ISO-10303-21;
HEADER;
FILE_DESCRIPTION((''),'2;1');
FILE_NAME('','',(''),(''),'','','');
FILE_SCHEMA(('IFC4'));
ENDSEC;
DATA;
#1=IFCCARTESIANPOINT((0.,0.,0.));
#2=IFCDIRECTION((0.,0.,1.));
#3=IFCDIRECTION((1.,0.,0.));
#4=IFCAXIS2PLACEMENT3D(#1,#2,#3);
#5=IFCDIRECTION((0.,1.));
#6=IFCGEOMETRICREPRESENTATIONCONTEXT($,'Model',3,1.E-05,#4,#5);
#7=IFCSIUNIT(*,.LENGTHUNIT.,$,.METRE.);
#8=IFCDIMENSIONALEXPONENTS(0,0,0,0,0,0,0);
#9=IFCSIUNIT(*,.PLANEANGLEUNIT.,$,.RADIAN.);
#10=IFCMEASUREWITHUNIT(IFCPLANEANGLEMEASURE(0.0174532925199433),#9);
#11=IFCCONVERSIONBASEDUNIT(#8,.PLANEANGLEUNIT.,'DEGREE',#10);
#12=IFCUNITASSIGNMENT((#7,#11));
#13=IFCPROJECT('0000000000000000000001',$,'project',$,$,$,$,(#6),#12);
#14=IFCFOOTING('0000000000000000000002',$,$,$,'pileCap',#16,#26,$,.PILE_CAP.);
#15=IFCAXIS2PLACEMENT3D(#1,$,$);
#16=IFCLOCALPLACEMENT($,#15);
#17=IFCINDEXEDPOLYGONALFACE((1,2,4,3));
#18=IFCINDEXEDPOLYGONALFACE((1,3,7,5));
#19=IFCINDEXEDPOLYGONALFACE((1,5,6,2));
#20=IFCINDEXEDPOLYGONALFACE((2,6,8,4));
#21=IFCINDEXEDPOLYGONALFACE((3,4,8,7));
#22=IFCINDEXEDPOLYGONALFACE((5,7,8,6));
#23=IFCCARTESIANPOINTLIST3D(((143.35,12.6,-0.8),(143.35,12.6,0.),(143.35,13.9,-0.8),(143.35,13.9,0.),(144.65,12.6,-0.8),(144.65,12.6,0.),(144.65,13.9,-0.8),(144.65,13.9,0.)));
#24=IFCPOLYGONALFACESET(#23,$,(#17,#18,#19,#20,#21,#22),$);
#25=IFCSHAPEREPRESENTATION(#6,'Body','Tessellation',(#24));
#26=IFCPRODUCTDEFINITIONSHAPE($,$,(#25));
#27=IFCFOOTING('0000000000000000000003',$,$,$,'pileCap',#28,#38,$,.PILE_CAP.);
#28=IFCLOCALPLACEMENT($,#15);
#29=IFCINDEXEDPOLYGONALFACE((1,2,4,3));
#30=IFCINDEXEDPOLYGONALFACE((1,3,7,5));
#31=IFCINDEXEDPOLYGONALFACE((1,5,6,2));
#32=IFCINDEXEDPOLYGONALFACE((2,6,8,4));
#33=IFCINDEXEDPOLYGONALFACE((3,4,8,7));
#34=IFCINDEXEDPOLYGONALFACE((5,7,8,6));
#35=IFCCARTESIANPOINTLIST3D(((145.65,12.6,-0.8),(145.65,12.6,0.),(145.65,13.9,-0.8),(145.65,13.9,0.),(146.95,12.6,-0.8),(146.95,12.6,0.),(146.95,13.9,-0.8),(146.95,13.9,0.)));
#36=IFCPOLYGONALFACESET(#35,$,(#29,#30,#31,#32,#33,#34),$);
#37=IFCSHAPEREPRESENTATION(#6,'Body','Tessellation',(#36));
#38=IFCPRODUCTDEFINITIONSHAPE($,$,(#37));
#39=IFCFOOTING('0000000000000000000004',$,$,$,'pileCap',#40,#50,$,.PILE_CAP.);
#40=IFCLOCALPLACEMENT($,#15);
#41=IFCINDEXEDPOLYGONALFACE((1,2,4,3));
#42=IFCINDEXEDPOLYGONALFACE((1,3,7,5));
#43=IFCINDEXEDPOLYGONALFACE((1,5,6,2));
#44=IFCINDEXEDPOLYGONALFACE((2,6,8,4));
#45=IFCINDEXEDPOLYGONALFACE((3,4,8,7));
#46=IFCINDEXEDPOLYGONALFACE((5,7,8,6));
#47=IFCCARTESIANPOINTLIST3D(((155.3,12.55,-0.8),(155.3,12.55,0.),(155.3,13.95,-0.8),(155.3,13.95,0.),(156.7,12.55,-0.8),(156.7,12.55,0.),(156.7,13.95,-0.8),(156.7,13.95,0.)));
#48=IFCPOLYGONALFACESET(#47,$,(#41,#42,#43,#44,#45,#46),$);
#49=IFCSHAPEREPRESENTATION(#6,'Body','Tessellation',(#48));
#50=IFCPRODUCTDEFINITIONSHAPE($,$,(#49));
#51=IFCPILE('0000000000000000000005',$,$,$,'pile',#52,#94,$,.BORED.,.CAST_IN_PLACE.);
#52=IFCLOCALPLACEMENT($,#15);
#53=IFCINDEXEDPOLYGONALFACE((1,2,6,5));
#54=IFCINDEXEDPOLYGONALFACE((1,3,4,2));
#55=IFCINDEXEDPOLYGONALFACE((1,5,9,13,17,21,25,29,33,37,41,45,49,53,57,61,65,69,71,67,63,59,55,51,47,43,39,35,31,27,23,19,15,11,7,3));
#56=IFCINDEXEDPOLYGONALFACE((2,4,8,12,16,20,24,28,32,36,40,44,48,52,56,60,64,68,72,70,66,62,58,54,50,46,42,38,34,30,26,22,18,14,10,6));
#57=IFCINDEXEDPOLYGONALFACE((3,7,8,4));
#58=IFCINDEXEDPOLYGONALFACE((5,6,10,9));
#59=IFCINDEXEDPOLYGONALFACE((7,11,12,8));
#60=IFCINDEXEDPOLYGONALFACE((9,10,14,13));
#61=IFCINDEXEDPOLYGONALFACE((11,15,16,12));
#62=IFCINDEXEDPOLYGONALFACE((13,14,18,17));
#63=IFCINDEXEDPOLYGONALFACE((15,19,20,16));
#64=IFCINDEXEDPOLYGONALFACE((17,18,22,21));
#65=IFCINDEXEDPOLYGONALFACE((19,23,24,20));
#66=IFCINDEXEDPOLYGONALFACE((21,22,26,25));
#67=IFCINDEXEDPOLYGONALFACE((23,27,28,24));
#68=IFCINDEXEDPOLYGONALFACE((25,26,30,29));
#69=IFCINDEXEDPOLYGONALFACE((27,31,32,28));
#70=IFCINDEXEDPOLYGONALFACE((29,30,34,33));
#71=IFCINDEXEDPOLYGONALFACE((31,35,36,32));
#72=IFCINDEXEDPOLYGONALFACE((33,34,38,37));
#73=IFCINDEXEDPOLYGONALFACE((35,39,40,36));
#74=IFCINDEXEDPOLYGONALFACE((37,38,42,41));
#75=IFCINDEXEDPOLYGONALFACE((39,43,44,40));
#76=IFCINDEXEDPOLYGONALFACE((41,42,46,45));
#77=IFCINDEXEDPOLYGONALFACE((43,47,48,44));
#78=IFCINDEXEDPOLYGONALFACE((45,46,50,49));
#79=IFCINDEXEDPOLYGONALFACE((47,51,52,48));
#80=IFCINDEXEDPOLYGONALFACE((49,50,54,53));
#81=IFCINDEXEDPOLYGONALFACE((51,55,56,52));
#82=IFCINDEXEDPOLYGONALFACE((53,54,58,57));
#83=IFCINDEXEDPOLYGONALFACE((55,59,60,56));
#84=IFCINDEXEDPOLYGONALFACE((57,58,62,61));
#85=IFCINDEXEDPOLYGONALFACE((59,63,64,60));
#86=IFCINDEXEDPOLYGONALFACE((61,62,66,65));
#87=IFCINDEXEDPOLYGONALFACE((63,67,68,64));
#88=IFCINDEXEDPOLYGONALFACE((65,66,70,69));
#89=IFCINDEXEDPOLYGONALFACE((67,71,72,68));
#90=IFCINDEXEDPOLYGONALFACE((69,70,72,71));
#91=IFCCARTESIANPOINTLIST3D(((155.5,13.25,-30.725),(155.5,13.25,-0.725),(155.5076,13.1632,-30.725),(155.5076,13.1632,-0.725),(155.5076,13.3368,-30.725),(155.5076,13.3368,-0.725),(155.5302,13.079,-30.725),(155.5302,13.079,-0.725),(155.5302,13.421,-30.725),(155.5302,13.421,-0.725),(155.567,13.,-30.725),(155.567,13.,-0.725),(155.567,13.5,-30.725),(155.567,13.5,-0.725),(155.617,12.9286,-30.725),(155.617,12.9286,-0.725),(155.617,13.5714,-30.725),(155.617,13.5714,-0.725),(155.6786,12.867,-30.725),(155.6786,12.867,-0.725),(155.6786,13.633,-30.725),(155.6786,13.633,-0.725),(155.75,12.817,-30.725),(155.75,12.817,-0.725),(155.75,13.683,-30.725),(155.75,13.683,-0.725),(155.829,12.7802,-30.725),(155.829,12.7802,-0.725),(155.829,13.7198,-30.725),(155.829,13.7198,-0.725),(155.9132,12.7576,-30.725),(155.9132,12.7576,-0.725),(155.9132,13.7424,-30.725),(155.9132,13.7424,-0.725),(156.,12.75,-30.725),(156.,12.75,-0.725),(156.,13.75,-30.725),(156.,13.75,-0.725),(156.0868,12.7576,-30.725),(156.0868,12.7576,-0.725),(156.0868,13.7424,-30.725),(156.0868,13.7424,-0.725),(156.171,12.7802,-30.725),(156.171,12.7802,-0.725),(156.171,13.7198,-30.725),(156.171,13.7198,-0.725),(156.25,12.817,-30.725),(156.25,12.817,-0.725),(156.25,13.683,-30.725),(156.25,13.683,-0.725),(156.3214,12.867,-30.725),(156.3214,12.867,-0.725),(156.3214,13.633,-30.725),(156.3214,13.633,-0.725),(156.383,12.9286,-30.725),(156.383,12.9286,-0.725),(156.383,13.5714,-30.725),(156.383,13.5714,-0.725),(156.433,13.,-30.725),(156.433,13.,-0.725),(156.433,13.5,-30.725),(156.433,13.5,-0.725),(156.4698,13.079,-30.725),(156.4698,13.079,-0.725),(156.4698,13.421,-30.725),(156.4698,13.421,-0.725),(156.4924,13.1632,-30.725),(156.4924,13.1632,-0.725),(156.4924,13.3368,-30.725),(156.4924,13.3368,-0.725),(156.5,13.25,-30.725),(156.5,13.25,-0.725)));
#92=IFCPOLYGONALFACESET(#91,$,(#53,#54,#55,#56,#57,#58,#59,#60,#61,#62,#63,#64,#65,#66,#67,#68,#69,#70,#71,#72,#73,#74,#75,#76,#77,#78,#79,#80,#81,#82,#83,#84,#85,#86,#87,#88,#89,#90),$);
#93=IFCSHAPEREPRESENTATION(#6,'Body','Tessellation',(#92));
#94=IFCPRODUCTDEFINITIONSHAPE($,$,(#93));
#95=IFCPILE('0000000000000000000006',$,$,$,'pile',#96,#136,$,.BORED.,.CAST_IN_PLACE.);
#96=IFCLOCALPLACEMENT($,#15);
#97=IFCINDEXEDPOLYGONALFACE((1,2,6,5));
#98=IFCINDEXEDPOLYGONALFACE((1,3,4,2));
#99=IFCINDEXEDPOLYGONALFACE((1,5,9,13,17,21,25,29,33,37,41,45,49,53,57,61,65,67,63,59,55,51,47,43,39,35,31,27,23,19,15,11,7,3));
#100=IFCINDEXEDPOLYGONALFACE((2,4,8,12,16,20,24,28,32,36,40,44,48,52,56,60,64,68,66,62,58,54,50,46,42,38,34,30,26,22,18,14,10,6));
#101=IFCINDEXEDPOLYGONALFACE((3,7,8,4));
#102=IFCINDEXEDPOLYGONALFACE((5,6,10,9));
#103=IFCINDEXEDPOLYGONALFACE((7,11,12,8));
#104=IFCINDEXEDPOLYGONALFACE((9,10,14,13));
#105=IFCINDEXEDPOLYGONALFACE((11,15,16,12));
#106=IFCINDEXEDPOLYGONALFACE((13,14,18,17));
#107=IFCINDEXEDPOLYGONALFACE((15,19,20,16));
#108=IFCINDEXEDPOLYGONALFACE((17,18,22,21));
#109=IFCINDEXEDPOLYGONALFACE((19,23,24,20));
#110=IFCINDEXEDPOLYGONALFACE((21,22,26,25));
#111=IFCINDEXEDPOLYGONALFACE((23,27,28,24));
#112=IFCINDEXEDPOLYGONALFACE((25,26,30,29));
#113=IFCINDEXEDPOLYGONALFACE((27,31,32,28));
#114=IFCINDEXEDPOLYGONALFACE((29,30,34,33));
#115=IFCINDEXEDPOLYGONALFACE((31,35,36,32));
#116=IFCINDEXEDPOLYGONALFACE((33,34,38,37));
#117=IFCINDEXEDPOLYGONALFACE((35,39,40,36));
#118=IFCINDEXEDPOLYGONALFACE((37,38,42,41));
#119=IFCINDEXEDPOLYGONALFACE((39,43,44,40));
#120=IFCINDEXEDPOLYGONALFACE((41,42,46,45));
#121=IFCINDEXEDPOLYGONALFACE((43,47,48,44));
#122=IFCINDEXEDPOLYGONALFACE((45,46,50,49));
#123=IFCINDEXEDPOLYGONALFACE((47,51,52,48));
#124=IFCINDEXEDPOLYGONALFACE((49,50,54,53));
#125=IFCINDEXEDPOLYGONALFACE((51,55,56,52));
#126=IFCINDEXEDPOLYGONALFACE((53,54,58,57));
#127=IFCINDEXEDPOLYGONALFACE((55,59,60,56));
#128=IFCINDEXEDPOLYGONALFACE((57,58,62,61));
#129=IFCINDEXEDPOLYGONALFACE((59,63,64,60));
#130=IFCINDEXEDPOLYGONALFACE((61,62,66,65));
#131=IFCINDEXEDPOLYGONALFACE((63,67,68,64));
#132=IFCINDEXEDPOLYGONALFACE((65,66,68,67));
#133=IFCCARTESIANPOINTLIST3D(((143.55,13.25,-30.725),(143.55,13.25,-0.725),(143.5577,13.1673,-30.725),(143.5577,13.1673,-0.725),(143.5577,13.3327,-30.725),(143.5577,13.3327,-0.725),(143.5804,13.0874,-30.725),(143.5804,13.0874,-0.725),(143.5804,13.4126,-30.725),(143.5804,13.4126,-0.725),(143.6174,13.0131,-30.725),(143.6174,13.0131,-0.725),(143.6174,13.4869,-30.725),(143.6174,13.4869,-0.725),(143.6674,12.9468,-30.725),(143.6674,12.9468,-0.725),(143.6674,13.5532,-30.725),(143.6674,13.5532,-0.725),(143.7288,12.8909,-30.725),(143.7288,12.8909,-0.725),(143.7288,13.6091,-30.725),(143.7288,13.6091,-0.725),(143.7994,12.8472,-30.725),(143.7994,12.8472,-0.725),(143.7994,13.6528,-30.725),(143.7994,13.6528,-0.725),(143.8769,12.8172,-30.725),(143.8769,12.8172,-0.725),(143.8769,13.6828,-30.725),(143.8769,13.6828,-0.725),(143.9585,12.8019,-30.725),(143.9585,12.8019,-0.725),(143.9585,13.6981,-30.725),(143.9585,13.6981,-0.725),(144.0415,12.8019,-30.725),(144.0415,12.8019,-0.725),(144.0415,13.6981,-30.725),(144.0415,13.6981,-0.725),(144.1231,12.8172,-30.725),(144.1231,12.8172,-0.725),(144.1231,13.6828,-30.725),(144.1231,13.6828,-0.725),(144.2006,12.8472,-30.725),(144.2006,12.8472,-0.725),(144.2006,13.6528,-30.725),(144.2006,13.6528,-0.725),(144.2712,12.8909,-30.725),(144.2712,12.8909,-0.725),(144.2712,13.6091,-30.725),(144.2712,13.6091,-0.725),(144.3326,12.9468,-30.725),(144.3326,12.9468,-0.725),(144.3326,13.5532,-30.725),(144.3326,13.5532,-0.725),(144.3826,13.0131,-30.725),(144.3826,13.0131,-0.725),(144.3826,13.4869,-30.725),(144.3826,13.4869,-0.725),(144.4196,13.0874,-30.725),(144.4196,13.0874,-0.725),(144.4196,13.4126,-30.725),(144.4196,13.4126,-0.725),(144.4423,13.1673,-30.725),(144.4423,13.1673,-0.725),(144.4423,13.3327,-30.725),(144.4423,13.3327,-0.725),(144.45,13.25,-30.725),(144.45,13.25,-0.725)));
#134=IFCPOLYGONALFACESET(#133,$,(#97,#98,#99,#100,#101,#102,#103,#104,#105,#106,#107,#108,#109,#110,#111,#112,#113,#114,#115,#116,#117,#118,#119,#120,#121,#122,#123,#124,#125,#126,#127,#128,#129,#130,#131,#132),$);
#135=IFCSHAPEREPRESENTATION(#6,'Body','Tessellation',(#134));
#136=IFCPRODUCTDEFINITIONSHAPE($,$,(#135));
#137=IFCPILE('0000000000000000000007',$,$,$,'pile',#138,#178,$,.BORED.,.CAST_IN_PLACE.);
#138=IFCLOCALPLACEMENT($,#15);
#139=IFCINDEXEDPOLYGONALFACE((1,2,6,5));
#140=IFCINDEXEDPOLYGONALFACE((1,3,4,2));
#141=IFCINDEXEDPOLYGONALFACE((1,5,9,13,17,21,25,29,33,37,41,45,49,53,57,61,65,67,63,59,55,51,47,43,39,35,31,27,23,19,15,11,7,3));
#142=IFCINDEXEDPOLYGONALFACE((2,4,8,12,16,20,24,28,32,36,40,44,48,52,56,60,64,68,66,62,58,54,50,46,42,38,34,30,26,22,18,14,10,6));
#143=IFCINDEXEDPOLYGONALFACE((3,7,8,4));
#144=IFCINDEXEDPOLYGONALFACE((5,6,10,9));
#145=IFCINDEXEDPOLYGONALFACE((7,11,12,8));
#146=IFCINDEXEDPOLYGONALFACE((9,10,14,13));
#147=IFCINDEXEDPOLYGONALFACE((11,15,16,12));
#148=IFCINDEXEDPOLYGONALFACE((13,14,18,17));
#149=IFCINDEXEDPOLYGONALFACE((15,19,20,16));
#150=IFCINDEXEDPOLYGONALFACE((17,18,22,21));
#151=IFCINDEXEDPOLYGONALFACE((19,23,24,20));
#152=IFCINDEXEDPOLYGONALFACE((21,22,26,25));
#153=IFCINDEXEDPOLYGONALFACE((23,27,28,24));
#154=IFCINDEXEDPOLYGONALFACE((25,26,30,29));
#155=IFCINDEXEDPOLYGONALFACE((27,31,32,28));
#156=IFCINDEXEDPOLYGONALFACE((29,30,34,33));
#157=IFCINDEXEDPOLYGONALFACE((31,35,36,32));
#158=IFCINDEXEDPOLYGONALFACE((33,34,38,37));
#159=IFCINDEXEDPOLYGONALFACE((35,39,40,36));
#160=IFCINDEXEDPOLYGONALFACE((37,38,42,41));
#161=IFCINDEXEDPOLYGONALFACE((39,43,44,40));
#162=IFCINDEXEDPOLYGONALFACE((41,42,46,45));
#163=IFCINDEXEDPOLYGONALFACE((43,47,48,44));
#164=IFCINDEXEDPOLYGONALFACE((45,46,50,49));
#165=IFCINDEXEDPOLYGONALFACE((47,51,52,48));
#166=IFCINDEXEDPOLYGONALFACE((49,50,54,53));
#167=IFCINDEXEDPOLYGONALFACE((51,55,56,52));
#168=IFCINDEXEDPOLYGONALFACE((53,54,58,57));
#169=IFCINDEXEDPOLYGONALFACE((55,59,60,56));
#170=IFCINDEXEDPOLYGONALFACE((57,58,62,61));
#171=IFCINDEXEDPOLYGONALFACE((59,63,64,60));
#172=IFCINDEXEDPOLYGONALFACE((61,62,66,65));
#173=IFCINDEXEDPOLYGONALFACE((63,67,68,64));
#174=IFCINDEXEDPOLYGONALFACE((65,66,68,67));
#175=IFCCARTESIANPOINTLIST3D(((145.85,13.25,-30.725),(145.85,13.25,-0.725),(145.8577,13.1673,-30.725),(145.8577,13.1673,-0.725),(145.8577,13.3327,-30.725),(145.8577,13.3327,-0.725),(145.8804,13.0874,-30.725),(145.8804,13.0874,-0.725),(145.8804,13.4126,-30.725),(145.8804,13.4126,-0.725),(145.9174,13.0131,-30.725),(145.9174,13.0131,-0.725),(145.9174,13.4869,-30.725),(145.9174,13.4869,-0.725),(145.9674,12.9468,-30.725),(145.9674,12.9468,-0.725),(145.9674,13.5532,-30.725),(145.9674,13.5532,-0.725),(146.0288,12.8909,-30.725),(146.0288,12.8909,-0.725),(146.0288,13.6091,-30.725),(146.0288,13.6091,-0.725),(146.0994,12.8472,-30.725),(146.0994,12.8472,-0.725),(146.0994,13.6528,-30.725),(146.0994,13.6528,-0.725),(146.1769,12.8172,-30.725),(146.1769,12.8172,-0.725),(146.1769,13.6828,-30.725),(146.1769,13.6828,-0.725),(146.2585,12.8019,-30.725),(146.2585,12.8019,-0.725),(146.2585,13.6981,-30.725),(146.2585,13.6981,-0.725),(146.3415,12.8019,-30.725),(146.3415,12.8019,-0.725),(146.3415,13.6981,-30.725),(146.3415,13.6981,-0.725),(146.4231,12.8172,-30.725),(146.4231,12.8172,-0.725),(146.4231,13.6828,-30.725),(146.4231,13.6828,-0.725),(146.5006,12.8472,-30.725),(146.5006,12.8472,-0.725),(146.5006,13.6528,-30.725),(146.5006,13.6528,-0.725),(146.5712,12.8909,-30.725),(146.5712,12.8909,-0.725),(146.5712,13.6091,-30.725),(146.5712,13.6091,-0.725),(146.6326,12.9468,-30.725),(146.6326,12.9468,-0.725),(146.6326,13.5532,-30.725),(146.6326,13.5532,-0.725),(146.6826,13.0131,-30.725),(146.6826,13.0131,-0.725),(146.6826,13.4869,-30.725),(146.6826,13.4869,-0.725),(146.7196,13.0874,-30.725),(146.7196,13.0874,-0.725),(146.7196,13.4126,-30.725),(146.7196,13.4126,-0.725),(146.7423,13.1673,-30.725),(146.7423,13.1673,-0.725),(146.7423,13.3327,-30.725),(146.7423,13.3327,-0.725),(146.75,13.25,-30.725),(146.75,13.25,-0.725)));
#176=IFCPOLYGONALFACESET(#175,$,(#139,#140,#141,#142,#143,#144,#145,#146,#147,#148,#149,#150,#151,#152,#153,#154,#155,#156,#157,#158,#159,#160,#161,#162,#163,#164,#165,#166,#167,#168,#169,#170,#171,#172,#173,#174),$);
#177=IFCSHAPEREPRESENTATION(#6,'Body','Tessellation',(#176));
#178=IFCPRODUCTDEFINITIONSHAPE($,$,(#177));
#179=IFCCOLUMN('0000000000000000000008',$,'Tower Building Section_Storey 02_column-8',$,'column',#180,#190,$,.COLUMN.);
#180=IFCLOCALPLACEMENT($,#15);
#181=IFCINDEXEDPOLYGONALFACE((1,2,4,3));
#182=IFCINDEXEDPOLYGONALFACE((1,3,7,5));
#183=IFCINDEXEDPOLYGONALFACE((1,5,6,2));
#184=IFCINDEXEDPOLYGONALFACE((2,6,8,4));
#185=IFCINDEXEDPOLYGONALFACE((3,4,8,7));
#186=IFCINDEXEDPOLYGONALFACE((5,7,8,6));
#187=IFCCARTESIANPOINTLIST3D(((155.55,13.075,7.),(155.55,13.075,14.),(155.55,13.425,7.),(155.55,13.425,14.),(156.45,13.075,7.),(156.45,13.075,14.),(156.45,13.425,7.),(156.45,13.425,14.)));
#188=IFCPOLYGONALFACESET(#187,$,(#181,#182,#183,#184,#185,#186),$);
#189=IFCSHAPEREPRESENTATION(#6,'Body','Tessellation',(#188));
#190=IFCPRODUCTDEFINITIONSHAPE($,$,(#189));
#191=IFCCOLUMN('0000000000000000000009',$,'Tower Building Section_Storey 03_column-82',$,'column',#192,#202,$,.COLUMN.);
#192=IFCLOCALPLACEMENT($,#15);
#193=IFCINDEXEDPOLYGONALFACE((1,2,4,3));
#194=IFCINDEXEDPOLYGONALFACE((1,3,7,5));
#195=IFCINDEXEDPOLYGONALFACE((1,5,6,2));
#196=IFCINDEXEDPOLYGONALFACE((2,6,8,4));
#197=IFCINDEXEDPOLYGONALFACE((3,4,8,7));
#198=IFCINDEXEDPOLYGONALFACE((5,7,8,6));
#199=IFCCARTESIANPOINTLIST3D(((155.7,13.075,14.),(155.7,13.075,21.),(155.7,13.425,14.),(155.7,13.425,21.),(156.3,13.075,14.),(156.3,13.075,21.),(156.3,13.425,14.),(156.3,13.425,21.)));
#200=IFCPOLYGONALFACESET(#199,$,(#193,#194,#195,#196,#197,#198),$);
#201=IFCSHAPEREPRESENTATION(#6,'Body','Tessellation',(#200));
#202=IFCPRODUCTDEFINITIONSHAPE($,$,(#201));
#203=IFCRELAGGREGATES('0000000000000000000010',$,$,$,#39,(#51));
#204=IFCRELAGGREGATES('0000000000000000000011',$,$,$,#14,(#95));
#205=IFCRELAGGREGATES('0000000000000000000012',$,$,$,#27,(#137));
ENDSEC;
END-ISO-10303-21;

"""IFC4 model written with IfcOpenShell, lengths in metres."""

from ifc_helpers import new_model, entity, si_unit, converted_unit, direction, frame, origin_with_axes, place, context, project, polyline, circle_curve, parameter, trimmed, segment, composite_curve, outline, extrude, element, aggregate, save


model = new_model("IFC4")

# Units and contexts
model_context = context("Model", 3, precision=1e-05, world=origin_with_axes(), true_north=direction((0.0, 1.0)))
ifc_project = project(units=[si_unit("LENGTHUNIT", "METRE"), converted_unit("PLANEANGLEUNIT", "DEGREE", entity("IfcPlaneAngleMeasure", 0.0174532925199433), si_unit("PLANEANGLEUNIT", "RADIAN"), dimensions=[0, 0, 0, 0, 0, 0, 0])], contexts=[model_context])

# Footings
placement_1 = place(None, origin_with_axes())
placement_2 = place(placement_1, origin_with_axes())
footing_1_placement = place(placement_2, frame((144.0, 13.25, -0.8), z_axis=(0.0, 0.0, 1.0), x_axis=(1.0, 0.0, 0.0)))
footing_1 = element("IfcFooting", 1, at=footing_1_placement, ObjectType="pileCap", PredefinedType="PILE_CAP", context=model_context, body=[
    extrude(outline(polyline([(0.65, -0.65, 0.0), (0.65, 0.65, 0.0), (-0.65, 0.65, 0.0), (-0.65, -0.65, 0.0), (0.65, -0.65, 0.0)])), origin_with_axes(), (0.0, 0.0, 1.0), 0.8),
])
footing_2_placement = place(placement_2, frame((146.3, 13.25, -0.8), z_axis=(0.0, 0.0, 1.0), x_axis=(1.0, 0.0, 0.0)))
footing_2 = element("IfcFooting", 2, at=footing_2_placement, ObjectType="pileCap", PredefinedType="PILE_CAP", context=model_context, body=[
    extrude(outline(polyline([(0.65, -0.65, 0.0), (0.65, 0.65, 0.0), (-0.65, 0.65, 0.0), (-0.65, -0.65, 0.0), (0.65, -0.65, 0.0)])), origin_with_axes(), (0.0, 0.0, 1.0), 0.8),
])

# Footing, pile
footing_3_placement = place(placement_2, frame((156.0, 13.25, -0.8), z_axis=(0.0, 0.0, 1.0), x_axis=(1.0, 0.0, 0.0)))
footing_3 = element("IfcFooting", 3, at=footing_3_placement, ObjectType="pileCap", PredefinedType="PILE_CAP", context=model_context, body=[
    extrude(outline(polyline([(0.7, -0.7, 0.0), (0.7, 0.7, 0.0), (-0.7, 0.7, 0.0), (-0.7, -0.7, 0.0), (0.7, -0.7, 0.0)])), origin_with_axes(), (0.0, 0.0, 1.0), 0.8),
])
pile_1_placement = place(footing_3_placement, frame((0.0, 0.0, -29.925), z_axis=(0.0, 0.0, 1.0), x_axis=(1.0, 0.0, 0.0)))
pile_1 = element("IfcPile", 4, at=pile_1_placement, ObjectType="pile", ConstructionType="CAST_IN_PLACE", PredefinedType="BORED", context=model_context, body=[
    extrude(outline(composite_curve([segment(trimmed(circle_curve(origin_with_axes(), 0.5), [parameter(0.0)], [parameter(360.0)], True, "PARAMETER"), True, "CONTINUOUS")], self_intersect=False)), origin_with_axes(), (0.0, 0.0, 1.0), 30.0),
])
aggregate(footing_3, [pile_1])

# Piles
pile_2_placement = place(footing_1_placement, frame((0.0, 0.0, -29.925), z_axis=(0.0, 0.0, 1.0), x_axis=(1.0, 0.0, 0.0)))
pile_2 = element("IfcPile", 5, at=pile_2_placement, ObjectType="pile", ConstructionType="CAST_IN_PLACE", PredefinedType="BORED", context=model_context, body=[
    extrude(outline(composite_curve([segment(trimmed(circle_curve(origin_with_axes(), 0.45), [parameter(0.0)], [parameter(360.0)], True, "PARAMETER"), True, "CONTINUOUS")], self_intersect=False)), origin_with_axes(), (0.0, 0.0, 1.0), 30.0),
])
aggregate(footing_1, [pile_2])
pile_3_placement = place(footing_2_placement, frame((0.0, 0.0, -29.925), z_axis=(0.0, 0.0, 1.0), x_axis=(1.0, 0.0, 0.0)))
pile_3 = element("IfcPile", 6, at=pile_3_placement, ObjectType="pile", ConstructionType="CAST_IN_PLACE", PredefinedType="BORED", context=model_context, body=[
    extrude(outline(composite_curve([segment(trimmed(circle_curve(origin_with_axes(), 0.45), [parameter(0.0)], [parameter(360.0)], True, "PARAMETER"), True, "CONTINUOUS")], self_intersect=False)), origin_with_axes(), (0.0, 0.0, 1.0), 30.0),
])
aggregate(footing_2, [pile_3])

# Columns
placement_3 = place(placement_1, frame((0.0, 0.0, 7.0), z_axis=(0.0, 0.0, 1.0), x_axis=(1.0, 0.0, 0.0)))
column_1_placement = place(placement_3, frame((156.0, 13.25, 0.0), z_axis=(0.0, 0.0, 1.0), x_axis=(1.0, 0.0, 0.0)))
element("IfcColumn", 7, at=column_1_placement, Name="Tower Building Section_Storey 02_column-8", ObjectType="column", PredefinedType="COLUMN", context=model_context, body=[
    extrude(outline(polyline([(-0.45, -0.175, 0.0), (0.45, -0.175, 0.0), (0.45, 0.175, 0.0), (-0.45, 0.175, 0.0), (-0.45, -0.175, 0.0)])), origin_with_axes(), (0.0, 0.0, 1.0), 7.0),
])
placement_4 = place(placement_1, frame((0.0, 0.0, 14.0), z_axis=(0.0, 0.0, 1.0), x_axis=(1.0, 0.0, 0.0)))
column_2_placement = place(placement_4, frame((156.0, 13.25, 0.0), z_axis=(0.0, 0.0, 1.0), x_axis=(1.0, 0.0, 0.0)))
element("IfcColumn", 8, at=column_2_placement, Name="Tower Building Section_Storey 03_column-82", ObjectType="column", PredefinedType="COLUMN", context=model_context, body=[
    extrude(outline(polyline([(-0.3, -0.175, 0.0), (0.3, -0.175, 0.0), (0.3, 0.175, 0.0), (-0.3, 0.175, 0.0), (-0.3, -0.175, 0.0)])), origin_with_axes(), (0.0, 0.0, 1.0), 7.0),
])

save(model, "model.ifc")
